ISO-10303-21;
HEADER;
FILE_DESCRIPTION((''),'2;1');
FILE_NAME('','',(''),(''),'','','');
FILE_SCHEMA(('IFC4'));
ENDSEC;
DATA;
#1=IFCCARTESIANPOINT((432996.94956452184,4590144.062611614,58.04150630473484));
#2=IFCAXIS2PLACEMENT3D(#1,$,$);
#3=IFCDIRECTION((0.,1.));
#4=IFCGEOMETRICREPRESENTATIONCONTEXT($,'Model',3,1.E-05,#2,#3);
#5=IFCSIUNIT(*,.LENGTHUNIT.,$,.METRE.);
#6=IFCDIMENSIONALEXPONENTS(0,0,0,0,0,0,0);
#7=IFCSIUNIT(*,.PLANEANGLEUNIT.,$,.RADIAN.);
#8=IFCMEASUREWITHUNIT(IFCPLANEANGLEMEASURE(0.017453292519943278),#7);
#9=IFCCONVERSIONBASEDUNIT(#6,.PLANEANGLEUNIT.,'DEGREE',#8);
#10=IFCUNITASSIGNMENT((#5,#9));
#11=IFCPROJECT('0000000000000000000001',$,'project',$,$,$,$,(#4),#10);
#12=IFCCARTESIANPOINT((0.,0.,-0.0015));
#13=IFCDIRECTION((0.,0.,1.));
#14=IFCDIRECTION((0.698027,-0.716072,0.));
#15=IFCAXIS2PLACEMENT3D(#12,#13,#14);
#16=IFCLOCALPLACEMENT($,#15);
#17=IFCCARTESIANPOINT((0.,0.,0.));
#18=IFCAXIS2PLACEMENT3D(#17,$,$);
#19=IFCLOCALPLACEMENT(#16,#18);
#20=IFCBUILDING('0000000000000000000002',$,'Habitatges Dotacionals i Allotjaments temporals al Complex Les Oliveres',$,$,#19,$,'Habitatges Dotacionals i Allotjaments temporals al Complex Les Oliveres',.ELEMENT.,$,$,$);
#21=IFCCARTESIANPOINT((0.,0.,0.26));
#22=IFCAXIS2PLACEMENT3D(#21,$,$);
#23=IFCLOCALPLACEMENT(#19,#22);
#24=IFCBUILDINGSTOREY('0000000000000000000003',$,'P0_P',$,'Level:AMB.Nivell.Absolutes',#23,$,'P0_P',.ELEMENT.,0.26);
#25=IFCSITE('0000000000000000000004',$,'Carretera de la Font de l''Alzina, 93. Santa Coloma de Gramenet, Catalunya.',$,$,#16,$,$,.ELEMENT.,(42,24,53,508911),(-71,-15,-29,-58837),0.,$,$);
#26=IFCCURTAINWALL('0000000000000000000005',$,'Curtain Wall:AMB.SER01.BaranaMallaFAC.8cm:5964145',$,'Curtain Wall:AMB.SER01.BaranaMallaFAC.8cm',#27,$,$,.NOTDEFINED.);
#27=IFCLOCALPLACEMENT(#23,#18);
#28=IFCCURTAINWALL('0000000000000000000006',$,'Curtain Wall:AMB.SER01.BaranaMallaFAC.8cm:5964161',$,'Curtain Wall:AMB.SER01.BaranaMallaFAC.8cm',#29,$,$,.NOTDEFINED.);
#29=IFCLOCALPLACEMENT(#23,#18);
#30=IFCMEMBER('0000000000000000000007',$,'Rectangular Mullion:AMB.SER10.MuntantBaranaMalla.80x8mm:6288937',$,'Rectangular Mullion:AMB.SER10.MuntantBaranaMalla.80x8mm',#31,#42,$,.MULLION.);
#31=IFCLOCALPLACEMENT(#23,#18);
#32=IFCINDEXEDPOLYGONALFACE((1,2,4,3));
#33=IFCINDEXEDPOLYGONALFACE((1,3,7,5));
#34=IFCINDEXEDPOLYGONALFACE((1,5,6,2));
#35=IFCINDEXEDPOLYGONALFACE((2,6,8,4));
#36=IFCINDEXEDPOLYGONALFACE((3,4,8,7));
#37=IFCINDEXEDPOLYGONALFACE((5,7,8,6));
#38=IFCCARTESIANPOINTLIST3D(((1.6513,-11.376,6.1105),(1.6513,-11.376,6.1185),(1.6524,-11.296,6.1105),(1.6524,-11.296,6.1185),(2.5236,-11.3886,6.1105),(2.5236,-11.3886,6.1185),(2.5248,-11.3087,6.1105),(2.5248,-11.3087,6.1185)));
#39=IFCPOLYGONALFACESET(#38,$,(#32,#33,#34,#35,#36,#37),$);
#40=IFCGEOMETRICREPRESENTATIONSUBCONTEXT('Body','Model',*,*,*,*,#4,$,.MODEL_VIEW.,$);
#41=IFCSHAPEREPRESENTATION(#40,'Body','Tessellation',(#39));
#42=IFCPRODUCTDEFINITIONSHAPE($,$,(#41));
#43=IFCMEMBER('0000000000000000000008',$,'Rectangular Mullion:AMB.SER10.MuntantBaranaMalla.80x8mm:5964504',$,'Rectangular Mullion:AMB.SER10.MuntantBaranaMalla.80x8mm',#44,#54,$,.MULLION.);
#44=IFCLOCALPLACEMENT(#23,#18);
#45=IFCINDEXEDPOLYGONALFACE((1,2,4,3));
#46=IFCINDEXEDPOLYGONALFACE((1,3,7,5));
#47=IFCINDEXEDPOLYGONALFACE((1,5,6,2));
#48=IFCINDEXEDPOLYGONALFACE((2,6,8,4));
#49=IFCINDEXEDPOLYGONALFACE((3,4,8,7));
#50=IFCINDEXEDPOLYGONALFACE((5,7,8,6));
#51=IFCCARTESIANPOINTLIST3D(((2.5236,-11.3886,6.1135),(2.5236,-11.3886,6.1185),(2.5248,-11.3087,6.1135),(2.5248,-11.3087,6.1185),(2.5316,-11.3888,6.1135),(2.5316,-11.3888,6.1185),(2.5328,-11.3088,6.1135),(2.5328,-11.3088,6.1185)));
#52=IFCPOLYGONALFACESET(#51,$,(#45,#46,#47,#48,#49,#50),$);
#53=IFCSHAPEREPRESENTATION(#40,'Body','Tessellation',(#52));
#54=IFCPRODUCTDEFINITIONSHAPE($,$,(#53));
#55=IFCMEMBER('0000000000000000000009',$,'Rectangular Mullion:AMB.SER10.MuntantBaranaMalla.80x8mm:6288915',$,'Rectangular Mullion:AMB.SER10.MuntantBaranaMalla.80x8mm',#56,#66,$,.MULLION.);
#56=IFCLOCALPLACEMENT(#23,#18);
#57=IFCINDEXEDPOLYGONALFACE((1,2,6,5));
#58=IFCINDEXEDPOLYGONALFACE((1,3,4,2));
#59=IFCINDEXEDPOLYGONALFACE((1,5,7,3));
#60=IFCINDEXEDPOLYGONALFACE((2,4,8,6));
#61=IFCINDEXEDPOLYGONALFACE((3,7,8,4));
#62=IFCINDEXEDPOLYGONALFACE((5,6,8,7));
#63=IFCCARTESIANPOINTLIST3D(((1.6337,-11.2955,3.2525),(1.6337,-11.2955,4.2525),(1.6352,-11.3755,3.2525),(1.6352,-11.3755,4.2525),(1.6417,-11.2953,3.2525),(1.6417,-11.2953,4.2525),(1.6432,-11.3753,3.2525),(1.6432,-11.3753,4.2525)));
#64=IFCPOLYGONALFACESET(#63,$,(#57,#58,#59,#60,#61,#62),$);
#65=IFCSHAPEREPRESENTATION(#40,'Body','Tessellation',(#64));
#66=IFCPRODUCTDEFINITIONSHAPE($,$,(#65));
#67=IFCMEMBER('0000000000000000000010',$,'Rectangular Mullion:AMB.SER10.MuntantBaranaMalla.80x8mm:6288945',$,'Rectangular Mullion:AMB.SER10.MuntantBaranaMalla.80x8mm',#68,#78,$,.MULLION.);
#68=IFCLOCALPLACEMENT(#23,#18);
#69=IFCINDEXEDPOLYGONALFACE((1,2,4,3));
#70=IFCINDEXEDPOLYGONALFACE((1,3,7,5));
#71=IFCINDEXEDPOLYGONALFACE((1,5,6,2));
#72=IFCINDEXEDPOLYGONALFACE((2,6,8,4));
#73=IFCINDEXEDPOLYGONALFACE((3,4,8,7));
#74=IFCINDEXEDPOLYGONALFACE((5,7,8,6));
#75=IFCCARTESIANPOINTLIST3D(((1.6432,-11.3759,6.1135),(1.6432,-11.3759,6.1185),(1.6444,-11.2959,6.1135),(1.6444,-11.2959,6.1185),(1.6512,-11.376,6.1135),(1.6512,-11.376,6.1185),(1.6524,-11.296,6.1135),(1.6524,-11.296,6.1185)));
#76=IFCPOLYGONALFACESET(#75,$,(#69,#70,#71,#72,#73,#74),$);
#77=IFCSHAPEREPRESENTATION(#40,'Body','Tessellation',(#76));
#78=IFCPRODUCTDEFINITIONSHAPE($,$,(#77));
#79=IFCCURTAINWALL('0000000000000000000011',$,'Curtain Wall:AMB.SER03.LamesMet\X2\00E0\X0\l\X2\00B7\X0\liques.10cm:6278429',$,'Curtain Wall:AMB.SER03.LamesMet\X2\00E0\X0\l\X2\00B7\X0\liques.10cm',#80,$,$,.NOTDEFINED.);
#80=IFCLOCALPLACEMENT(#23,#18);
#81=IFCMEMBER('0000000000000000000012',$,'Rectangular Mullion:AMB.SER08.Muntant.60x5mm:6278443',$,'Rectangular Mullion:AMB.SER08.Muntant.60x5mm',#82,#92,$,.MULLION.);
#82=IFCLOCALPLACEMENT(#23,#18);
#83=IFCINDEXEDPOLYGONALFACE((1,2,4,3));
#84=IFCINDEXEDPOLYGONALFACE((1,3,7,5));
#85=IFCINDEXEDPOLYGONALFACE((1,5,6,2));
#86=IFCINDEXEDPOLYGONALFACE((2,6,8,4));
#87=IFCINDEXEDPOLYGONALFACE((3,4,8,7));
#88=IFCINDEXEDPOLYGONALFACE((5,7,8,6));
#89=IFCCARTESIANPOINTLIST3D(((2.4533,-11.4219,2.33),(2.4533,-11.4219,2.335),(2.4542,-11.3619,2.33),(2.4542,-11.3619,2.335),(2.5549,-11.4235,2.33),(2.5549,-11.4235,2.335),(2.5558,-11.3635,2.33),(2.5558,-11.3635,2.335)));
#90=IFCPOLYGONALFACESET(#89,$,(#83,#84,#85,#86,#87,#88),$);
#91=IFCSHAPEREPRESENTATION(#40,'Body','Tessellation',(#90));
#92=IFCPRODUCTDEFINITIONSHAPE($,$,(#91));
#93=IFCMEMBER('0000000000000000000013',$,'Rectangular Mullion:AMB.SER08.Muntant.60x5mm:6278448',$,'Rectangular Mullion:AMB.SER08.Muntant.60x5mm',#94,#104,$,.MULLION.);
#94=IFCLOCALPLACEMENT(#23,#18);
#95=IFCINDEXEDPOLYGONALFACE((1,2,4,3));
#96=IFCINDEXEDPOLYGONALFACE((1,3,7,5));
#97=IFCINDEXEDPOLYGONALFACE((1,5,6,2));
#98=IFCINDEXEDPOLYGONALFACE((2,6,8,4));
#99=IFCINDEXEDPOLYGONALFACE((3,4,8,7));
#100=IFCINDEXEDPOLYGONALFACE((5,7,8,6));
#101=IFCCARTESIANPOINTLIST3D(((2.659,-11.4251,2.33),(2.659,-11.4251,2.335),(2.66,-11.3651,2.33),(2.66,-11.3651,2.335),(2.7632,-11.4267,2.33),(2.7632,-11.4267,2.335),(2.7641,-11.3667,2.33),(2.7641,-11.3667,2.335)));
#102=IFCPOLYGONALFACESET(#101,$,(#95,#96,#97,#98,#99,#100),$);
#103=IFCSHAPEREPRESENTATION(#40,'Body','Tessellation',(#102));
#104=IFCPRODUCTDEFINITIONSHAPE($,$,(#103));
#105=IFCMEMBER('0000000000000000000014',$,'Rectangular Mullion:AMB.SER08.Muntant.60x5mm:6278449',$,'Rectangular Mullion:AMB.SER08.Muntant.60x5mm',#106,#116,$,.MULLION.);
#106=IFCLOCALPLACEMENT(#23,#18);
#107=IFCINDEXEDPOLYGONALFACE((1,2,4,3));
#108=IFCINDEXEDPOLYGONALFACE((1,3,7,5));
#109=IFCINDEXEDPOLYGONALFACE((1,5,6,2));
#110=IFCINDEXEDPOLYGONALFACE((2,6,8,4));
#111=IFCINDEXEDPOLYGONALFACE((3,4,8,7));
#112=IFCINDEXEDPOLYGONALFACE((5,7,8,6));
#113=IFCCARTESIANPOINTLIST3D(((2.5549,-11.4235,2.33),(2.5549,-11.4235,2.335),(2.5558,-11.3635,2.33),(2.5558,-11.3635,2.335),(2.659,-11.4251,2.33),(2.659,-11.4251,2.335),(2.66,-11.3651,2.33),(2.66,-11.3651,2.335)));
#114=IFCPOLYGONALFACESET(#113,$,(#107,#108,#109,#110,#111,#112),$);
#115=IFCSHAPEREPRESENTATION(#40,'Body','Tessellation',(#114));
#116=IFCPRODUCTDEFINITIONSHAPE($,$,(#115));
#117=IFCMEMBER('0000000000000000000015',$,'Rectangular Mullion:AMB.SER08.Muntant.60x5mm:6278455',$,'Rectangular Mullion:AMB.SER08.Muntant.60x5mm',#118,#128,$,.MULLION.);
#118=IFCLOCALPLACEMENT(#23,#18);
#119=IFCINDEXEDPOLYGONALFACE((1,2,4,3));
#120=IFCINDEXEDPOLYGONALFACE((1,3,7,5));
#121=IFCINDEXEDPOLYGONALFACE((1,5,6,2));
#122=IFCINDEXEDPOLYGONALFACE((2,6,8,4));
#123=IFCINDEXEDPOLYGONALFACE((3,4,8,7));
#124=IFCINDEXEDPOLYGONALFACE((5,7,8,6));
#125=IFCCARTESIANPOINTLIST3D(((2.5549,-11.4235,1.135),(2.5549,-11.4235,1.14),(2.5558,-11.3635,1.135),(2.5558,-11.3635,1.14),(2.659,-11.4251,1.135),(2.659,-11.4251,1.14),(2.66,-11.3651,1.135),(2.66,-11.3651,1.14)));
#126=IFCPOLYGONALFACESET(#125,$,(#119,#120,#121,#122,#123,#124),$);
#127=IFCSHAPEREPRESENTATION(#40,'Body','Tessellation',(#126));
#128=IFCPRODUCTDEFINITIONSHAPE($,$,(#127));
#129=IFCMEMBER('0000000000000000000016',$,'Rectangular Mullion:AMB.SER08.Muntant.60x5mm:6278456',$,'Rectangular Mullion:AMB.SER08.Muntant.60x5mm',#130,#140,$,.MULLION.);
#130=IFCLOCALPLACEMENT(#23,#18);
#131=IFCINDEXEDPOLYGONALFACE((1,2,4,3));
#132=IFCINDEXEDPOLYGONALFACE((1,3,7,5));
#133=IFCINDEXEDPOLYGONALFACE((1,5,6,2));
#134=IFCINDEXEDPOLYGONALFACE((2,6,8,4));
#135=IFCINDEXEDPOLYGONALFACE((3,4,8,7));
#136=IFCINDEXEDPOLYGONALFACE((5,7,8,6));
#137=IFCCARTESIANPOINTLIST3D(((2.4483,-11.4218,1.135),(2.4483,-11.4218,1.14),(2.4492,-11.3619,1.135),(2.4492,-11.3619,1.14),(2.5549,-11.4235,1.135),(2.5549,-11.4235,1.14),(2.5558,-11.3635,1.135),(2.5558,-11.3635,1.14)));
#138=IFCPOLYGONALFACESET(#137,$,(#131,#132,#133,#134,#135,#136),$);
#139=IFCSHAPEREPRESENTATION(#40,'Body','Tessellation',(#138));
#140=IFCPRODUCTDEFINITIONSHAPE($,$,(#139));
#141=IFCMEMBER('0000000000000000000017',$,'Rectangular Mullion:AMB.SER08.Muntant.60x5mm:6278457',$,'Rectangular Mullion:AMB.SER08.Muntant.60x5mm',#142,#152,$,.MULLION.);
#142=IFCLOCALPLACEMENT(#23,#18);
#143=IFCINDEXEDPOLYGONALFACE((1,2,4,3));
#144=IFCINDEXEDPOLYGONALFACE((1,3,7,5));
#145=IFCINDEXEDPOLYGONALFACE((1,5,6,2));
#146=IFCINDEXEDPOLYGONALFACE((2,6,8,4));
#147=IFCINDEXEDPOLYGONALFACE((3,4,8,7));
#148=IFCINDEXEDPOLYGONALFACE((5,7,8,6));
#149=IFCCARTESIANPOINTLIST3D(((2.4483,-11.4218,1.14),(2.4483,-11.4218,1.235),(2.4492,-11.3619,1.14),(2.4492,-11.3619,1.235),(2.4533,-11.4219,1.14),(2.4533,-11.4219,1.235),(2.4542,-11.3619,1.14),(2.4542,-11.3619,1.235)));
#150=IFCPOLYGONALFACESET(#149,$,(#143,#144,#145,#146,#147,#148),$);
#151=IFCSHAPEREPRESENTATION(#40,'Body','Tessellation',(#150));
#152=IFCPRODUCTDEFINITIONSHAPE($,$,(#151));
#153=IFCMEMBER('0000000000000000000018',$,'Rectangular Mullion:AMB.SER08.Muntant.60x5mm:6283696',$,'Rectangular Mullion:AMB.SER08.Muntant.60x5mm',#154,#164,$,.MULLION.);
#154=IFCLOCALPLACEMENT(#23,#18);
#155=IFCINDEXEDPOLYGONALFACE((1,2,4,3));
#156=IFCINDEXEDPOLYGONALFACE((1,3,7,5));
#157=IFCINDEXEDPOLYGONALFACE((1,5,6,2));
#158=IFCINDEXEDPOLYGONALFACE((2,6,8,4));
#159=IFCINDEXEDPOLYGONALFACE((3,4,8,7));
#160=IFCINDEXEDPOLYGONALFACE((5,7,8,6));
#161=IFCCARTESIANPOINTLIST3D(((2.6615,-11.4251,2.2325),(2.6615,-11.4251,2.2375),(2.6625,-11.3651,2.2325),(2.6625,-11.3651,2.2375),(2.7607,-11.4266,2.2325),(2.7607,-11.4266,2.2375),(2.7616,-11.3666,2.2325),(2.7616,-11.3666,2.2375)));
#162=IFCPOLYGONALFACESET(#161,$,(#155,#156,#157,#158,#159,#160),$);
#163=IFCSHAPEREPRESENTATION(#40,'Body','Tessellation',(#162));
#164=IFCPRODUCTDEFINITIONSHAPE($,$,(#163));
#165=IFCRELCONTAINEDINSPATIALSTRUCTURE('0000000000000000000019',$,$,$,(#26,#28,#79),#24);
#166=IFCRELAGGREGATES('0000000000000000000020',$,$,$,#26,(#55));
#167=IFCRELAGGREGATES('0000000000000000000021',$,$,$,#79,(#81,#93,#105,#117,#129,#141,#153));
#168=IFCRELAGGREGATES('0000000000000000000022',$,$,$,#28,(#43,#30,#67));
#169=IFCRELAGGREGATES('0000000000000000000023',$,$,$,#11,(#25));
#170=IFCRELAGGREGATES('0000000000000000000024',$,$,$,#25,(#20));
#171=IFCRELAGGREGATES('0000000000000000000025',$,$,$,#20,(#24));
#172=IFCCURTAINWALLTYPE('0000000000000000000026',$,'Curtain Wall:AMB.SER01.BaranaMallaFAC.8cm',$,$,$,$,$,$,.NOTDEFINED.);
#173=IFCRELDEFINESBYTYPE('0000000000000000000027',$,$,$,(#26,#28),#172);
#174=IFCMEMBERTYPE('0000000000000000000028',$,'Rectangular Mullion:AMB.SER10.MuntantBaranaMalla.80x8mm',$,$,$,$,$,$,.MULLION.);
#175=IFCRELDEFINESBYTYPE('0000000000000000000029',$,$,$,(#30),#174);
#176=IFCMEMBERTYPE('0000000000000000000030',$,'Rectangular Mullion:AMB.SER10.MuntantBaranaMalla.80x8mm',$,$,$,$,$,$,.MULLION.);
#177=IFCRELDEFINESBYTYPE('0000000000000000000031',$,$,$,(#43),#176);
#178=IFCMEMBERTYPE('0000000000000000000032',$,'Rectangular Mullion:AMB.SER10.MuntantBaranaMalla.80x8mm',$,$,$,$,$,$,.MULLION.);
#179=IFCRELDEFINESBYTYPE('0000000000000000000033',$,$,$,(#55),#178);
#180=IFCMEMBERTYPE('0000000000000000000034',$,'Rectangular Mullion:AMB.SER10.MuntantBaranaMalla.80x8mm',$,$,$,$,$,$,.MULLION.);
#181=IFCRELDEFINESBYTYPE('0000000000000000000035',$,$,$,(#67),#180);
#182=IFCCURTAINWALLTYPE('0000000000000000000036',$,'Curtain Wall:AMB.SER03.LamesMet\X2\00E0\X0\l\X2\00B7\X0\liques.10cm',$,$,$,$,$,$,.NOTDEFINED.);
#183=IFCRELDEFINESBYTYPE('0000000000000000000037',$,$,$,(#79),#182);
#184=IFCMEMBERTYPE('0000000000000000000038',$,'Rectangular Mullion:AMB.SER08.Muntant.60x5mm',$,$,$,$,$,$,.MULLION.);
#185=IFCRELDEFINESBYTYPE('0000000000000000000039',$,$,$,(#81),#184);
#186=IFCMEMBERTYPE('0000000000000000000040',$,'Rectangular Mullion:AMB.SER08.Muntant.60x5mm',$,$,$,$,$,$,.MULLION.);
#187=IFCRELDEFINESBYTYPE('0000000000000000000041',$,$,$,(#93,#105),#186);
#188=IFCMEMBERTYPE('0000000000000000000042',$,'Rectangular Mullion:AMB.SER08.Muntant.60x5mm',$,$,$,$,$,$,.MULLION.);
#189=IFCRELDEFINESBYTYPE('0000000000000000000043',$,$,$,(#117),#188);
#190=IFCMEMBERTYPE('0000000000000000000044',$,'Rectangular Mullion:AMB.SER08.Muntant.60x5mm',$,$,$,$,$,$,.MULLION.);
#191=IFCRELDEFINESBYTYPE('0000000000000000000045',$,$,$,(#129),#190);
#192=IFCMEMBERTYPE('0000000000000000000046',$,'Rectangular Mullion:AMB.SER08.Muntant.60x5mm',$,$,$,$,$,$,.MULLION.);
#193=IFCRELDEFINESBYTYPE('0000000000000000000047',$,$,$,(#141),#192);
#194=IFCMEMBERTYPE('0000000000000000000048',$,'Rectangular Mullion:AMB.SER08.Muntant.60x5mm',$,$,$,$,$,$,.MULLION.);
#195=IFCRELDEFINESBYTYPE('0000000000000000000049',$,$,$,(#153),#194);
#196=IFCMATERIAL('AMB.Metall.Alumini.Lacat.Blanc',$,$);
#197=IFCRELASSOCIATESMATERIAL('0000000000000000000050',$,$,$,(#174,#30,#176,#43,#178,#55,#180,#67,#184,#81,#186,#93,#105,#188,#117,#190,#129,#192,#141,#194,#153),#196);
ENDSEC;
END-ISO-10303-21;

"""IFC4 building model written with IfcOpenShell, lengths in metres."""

from ifc_helpers import new_model, entity, si_unit, converted_unit, direction, frame, origin, place, context, subcontext, project, spatial, indexed_curve, outline, extrude, source, transform, mapped, material, type_object, type_shapes, element, aggregate, save


model = new_model("IFC4")

# Units and contexts
model_context = context("Model", 3, precision=1e-05, world=frame((432996.94956452184, 4590144.062611614, 58.04150630473484)), true_north=direction((0.0, 1.0)))
body_context = subcontext(model_context, "Body", "Model", "MODEL_VIEW")
ifc_project = project(units=[si_unit("LENGTHUNIT", "METRE"), converted_unit("PLANEANGLEUNIT", "DEGREE", entity("IfcPlaneAngleMeasure", 0.017453292519943278), si_unit("PLANEANGLEUNIT", "RADIAN"), dimensions=[0, 0, 0, 0, 0, 0, 0])], contexts=[model_context])

# Site, building, storey
site_placement = place(None, frame((0.0, 0.0, -0.0015), z_axis=(0.0, 0.0, 1.0), x_axis=(0.698027, -0.716072, 0.0)))
site = spatial("IfcSite", under=ifc_project, at=site_placement, Name="Carretera de la Font de l'Alzina, 93. Santa Coloma de Gramenet, Catalunya.", CompositionType="ELEMENT", RefLatitude=(42, 24, 53, 508911), RefLongitude=(-71, -15, -29, -58837), RefElevation=0.0)
building_placement = place(site_placement, origin())
building = spatial("IfcBuilding", under=site, at=building_placement, Name="Habitatges Dotacionals i Allotjaments temporals al Complex Les Oliveres", LongName="Habitatges Dotacionals i Allotjaments temporals al Complex Les Oliveres", CompositionType="ELEMENT")
storey_placement = place(building_placement, frame((0.0, 0.0, 0.26)))
storey = spatial("IfcBuildingStorey", under=building, at=storey_placement, Name="P0_P", ObjectType="Level:AMB.Nivell.Absolutes", LongName="P0_P", CompositionType="ELEMENT", Elevation=0.26)

# Curtain wall
curtain_wall_type_1 = type_object("IfcCurtainWallType", Name="Curtain Wall:AMB.SER01.BaranaMallaFAC.8cm", PredefinedType="NOTDEFINED")
curtain_wall_1_placement = place(storey_placement, frame((0.0, 0.0, -0.26)))
curtain_wall_1 = element("IfcCurtainWall", 1, at=curtain_wall_1_placement, inside=storey, type_object=curtain_wall_type_1, Name="Curtain Wall:AMB.SER01.BaranaMallaFAC.8cm:5964145", ObjectType="Curtain Wall:AMB.SER01.BaranaMallaFAC.8cm", PredefinedType="NOTDEFINED")
ifc_material_1 = material(Name="AMB.Metall.Alumini.Lacat.Blanc")

# Curtain wall, members
curtain_wall_2_placement = place(storey_placement, frame((0.0, 0.0, -0.26)))
curtain_wall_2 = element("IfcCurtainWall", 2, at=curtain_wall_2_placement, inside=storey, type_object=curtain_wall_type_1, Name="Curtain Wall:AMB.SER01.BaranaMallaFAC.8cm:5964161", ObjectType="Curtain Wall:AMB.SER01.BaranaMallaFAC.8cm", PredefinedType="NOTDEFINED")
member_type_1 = type_object("IfcMemberType", Name="Rectangular Mullion:AMB.SER10.MuntantBaranaMalla.80x8mm", PredefinedType="MULLION", material=ifc_material_1)
shared_shape_1 = source(origin(), body_context, "Body", "SweptSolid", [
    extrude(outline(indexed_curve([(-0.004, -0.04), (0.004, -0.04), (0.004, 0.04), (-0.004, 0.04), (-0.004, -0.04)], self_intersect=False)), frame((-0.004, -0.04, -0.8724), z_axis=(0.0, 0.0, 1.0), x_axis=(-1.0, 0.0, 0.0)), (0.0, 0.0, 1.0), 0.8724),
])
type_shapes(member_type_1, [shared_shape_1])
member_1_placement = place(curtain_wall_2_placement, frame((2.5236, -11.3886, 6.3785), z_axis=(0.999895, -0.014473, 0.0), x_axis=(0.0, 0.0, 1.0)))
member_1 = element("IfcMember", 3, at=member_1_placement, type_object=member_type_1, material=ifc_material_1, Name="Rectangular Mullion:AMB.SER10.MuntantBaranaMalla.80x8mm:6288937", ObjectType="Rectangular Mullion:AMB.SER10.MuntantBaranaMalla.80x8mm", PredefinedType="MULLION", context=body_context, shape_type="MappedRepresentation", body=[
    mapped(shared_shape_1, transform((0.0, 0.0, 0.0), scale=1.0)),
])
member_type_2 = type_object("IfcMemberType", Name="Rectangular Mullion:AMB.SER10.MuntantBaranaMalla.80x8mm", PredefinedType="MULLION", material=ifc_material_1)
shared_shape_2 = source(origin(), body_context, "Body", "SweptSolid", [
    extrude(outline(indexed_curve([(-0.004, -0.04), (0.004, -0.04), (0.004, 0.04), (-0.004, 0.04), (-0.004, -0.04)], self_intersect=False)), frame((0.0, -0.04, -0.005), z_axis=(0.0, 0.0, 1.0), x_axis=(-1.0, 0.0, 0.0)), (0.0, 0.0, 1.0), 0.005),
])
type_shapes(member_type_2, [shared_shape_2])
member_2_placement = place(curtain_wall_2_placement, frame((2.5276, -11.3887, 6.3735), z_axis=(0.0, 0.0, -1.0), x_axis=(0.999895, -0.014473, 0.0)))
member_2 = element("IfcMember", 4, at=member_2_placement, type_object=member_type_2, material=ifc_material_1, Name="Rectangular Mullion:AMB.SER10.MuntantBaranaMalla.80x8mm:5964504", ObjectType="Rectangular Mullion:AMB.SER10.MuntantBaranaMalla.80x8mm", PredefinedType="MULLION", context=body_context, shape_type="MappedRepresentation", body=[
    mapped(shared_shape_2, transform((0.0, 0.0, 0.0), scale=1.0)),
])

# Members
member_type_3 = type_object("IfcMemberType", Name="Rectangular Mullion:AMB.SER10.MuntantBaranaMalla.80x8mm", PredefinedType="MULLION", material=ifc_material_1)
shared_shape_3 = source(origin(), body_context, "Body", "SweptSolid", [
    extrude(outline(indexed_curve([(-0.004, -0.04), (0.004, -0.04), (0.004, 0.04), (-0.004, 0.04), (-0.004, -0.04)], self_intersect=False)), frame((-0.004, -0.04, -1.0), z_axis=(0.0, 0.0, 1.0), x_axis=(-1.0, 0.0, 0.0)), (0.0, 0.0, 1.0), 1.0),
])
type_shapes(member_type_3, [shared_shape_3])
member_3_placement = place(curtain_wall_1_placement, frame((1.6432, -11.3753, 3.5125), z_axis=(0.0, 0.0, -1.0), x_axis=(0.999822, 0.018842, 0.0)))
member_3 = element("IfcMember", 5, at=member_3_placement, type_object=member_type_3, material=ifc_material_1, Name="Rectangular Mullion:AMB.SER10.MuntantBaranaMalla.80x8mm:6288915", ObjectType="Rectangular Mullion:AMB.SER10.MuntantBaranaMalla.80x8mm", PredefinedType="MULLION", context=body_context, shape_type="MappedRepresentation", body=[
    mapped(shared_shape_3, transform((0.0, 0.0, 0.0), scale=1.0)),
])
aggregate(curtain_wall_1, [member_3])
member_type_4 = type_object("IfcMemberType", Name="Rectangular Mullion:AMB.SER10.MuntantBaranaMalla.80x8mm", PredefinedType="MULLION", material=ifc_material_1)
shared_shape_4 = source(origin(), body_context, "Body", "SweptSolid", [
    extrude(outline(indexed_curve([(-0.004, -0.04), (0.004, -0.04), (0.004, 0.04), (-0.004, 0.04), (-0.004, -0.04)], self_intersect=False)), frame((-0.004, -0.04, -0.005), z_axis=(0.0, 0.0, 1.0), x_axis=(-1.0, 0.0, 0.0)), (0.0, 0.0, 1.0), 0.005),
])
type_shapes(member_type_4, [shared_shape_4])
member_4_placement = place(curtain_wall_2_placement, frame((1.6432, -11.3759, 6.3785), z_axis=(0.0, 0.0, 1.0), x_axis=(-0.999895, 0.014473, 0.0)))
member_4 = element("IfcMember", 6, at=member_4_placement, type_object=member_type_4, material=ifc_material_1, Name="Rectangular Mullion:AMB.SER10.MuntantBaranaMalla.80x8mm:6288945", ObjectType="Rectangular Mullion:AMB.SER10.MuntantBaranaMalla.80x8mm", PredefinedType="MULLION", context=body_context, shape_type="MappedRepresentation", body=[
    mapped(shared_shape_4, transform((0.0, 0.0, 0.0), scale=1.0)),
])

# Curtain wall, members
curtain_wall_type_2 = type_object("IfcCurtainWallType", Name="Curtain Wall:AMB.SER03.LamesMetàl·liques.10cm", PredefinedType="NOTDEFINED")
curtain_wall_3_placement = place(storey_placement, frame((0.0, 0.0, -0.26)))
curtain_wall_3 = element("IfcCurtainWall", 7, at=curtain_wall_3_placement, inside=storey, type_object=curtain_wall_type_2, Name="Curtain Wall:AMB.SER03.LamesMetàl·liques.10cm:6278429", ObjectType="Curtain Wall:AMB.SER03.LamesMetàl·liques.10cm", PredefinedType="NOTDEFINED")
member_type_5 = type_object("IfcMemberType", Name="Rectangular Mullion:AMB.SER08.Muntant.60x5mm", PredefinedType="MULLION", material=ifc_material_1)
shared_shape_5 = source(origin(), body_context, "Body", "SweptSolid", [
    extrude(outline(indexed_curve([(-0.0025, -0.03), (0.0025, -0.03), (0.0025, 0.03), (-0.0025, 0.03), (-0.0025, -0.03)], self_intersect=False)), frame((-0.0025, 0.03, -0.1016), z_axis=(0.0, 0.0, 1.0), x_axis=(-1.0, 0.0, 0.0)), (0.0, 0.0, 1.0), 0.1016),
])
type_shapes(member_type_5, [shared_shape_5])
member_5_placement = place(curtain_wall_3_placement, frame((2.4533, -11.4219, 2.595), z_axis=(-0.999883, 0.015319, 0.0), x_axis=(0.0, 0.0, 1.0)))
member_5 = element("IfcMember", 8, at=member_5_placement, type_object=member_type_5, material=ifc_material_1, Name="Rectangular Mullion:AMB.SER08.Muntant.60x5mm:6278443", ObjectType="Rectangular Mullion:AMB.SER08.Muntant.60x5mm", PredefinedType="MULLION", context=body_context, shape_type="MappedRepresentation", body=[
    mapped(shared_shape_5, transform((0.0, 0.0, 0.0), scale=1.0)),
])
member_type_6 = type_object("IfcMemberType", Name="Rectangular Mullion:AMB.SER08.Muntant.60x5mm", PredefinedType="MULLION", material=ifc_material_1)
shared_shape_6 = source(origin(), body_context, "Body", "SweptSolid", [
    extrude(outline(indexed_curve([(-0.0025, -0.03), (0.0025, -0.03), (0.0025, 0.03), (-0.0025, 0.03), (-0.0025, -0.03)], self_intersect=False)), frame((-0.0025, 0.03, -0.1041), z_axis=(0.0, 0.0, 1.0), x_axis=(-1.0, 0.0, 0.0)), (0.0, 0.0, 1.0), 0.1041),
])
type_shapes(member_type_6, [shared_shape_6])
member_6_placement = place(curtain_wall_3_placement, frame((2.659, -11.4251, 2.595), z_axis=(-0.999883, 0.015319, 0.0), x_axis=(0.0, 0.0, 1.0)))
member_6 = element("IfcMember", 9, at=member_6_placement, type_object=member_type_6, material=ifc_material_1, Name="Rectangular Mullion:AMB.SER08.Muntant.60x5mm:6278448", ObjectType="Rectangular Mullion:AMB.SER08.Muntant.60x5mm", PredefinedType="MULLION", context=body_context, shape_type="MappedRepresentation", body=[
    mapped(shared_shape_6, transform((0.0, 0.0, 0.0), scale=1.0)),
])
member_7_placement = place(curtain_wall_3_placement, frame((2.5549, -11.4235, 2.595), z_axis=(-0.999883, 0.015319, 0.0), x_axis=(0.0, 0.0, 1.0)))
member_7 = element("IfcMember", 10, at=member_7_placement, type_object=member_type_6, material=ifc_material_1, Name="Rectangular Mullion:AMB.SER08.Muntant.60x5mm:6278449", ObjectType="Rectangular Mullion:AMB.SER08.Muntant.60x5mm", PredefinedType="MULLION", context=body_context, shape_type="MappedRepresentation", body=[
    mapped(shared_shape_6, transform((0.0, 0.0, 0.0), scale=1.0)),
])
member_type_7 = type_object("IfcMemberType", Name="Rectangular Mullion:AMB.SER08.Muntant.60x5mm", PredefinedType="MULLION", material=ifc_material_1)
shared_shape_7 = source(origin(), body_context, "Body", "SweptSolid", [
    extrude(outline(indexed_curve([(-0.0025, -0.03), (0.0025, -0.03), (0.0025, 0.03), (-0.0025, 0.03), (-0.0025, -0.03)], self_intersect=False)), frame((-0.0025, 0.03, -0.1041), z_axis=(0.0, 0.0, 1.0), x_axis=(-1.0, 0.0, 0.0)), (0.0, 0.0, 1.0), 0.1041),
])
type_shapes(member_type_7, [shared_shape_7])
member_8_placement = place(curtain_wall_3_placement, frame((2.659, -11.4251, 1.395), z_axis=(0.999883, -0.015319, 0.0), x_axis=(0.0, 0.0, -1.0)))
member_8 = element("IfcMember", 11, at=member_8_placement, type_object=member_type_7, material=ifc_material_1, Name="Rectangular Mullion:AMB.SER08.Muntant.60x5mm:6278455", ObjectType="Rectangular Mullion:AMB.SER08.Muntant.60x5mm", PredefinedType="MULLION", context=body_context, shape_type="MappedRepresentation", body=[
    mapped(shared_shape_7, transform((0.0, 0.0, 0.0), scale=1.0)),
])
member_type_8 = type_object("IfcMemberType", Name="Rectangular Mullion:AMB.SER08.Muntant.60x5mm", PredefinedType="MULLION", material=ifc_material_1)
shared_shape_8 = source(origin(), body_context, "Body", "SweptSolid", [
    extrude(outline(indexed_curve([(-0.0025, -0.03), (0.0025, -0.03), (0.0025, 0.03), (-0.0025, 0.03), (-0.0025, -0.03)], self_intersect=False)), frame((-0.0025, 0.03, -0.1066), z_axis=(0.0, 0.0, 1.0), x_axis=(-1.0, 0.0, 0.0)), (0.0, 0.0, 1.0), 0.1066),
])
type_shapes(member_type_8, [shared_shape_8])
member_9_placement = place(curtain_wall_3_placement, frame((2.5549, -11.4235, 1.395), z_axis=(0.999883, -0.015319, 0.0), x_axis=(0.0, 0.0, -1.0)))
member_9 = element("IfcMember", 12, at=member_9_placement, type_object=member_type_8, material=ifc_material_1, Name="Rectangular Mullion:AMB.SER08.Muntant.60x5mm:6278456", ObjectType="Rectangular Mullion:AMB.SER08.Muntant.60x5mm", PredefinedType="MULLION", context=body_context, shape_type="MappedRepresentation", body=[
    mapped(shared_shape_8, transform((0.0, 0.0, 0.0), scale=1.0)),
])
member_type_9 = type_object("IfcMemberType", Name="Rectangular Mullion:AMB.SER08.Muntant.60x5mm", PredefinedType="MULLION", material=ifc_material_1)
shared_shape_9 = source(origin(), body_context, "Body", "SweptSolid", [
    extrude(outline(indexed_curve([(-0.0025, -0.03), (0.0025, -0.03), (0.0025, 0.03), (-0.0025, 0.03), (-0.0025, -0.03)], self_intersect=False)), frame((-0.0025, 0.03, -0.095), z_axis=(0.0, 0.0, 1.0), x_axis=(-1.0, 0.0, 0.0)), (0.0, 0.0, 1.0), 0.095),
])
type_shapes(member_type_9, [shared_shape_9])
member_10_placement = place(curtain_wall_3_placement, frame((2.4483, -11.4218, 1.4), z_axis=(0.0, 0.0, -1.0), x_axis=(-0.999883, 0.015319, 0.0)))
member_10 = element("IfcMember", 13, at=member_10_placement, type_object=member_type_9, material=ifc_material_1, Name="Rectangular Mullion:AMB.SER08.Muntant.60x5mm:6278457", ObjectType="Rectangular Mullion:AMB.SER08.Muntant.60x5mm", PredefinedType="MULLION", context=body_context, shape_type="MappedRepresentation", body=[
    mapped(shared_shape_9, transform((0.0, 0.0, 0.0), scale=1.0)),
])
member_type_10 = type_object("IfcMemberType", Name="Rectangular Mullion:AMB.SER08.Muntant.60x5mm", PredefinedType="MULLION", material=ifc_material_1)
shared_shape_10 = source(origin(), body_context, "Body", "SweptSolid", [
    extrude(outline(indexed_curve([(-0.0025, -0.03), (0.0025, -0.03), (0.0025, 0.03), (-0.0025, 0.03), (-0.0025, -0.03)], self_intersect=False)), frame((0.0, 0.03, -0.0991), z_axis=(0.0, 0.0, 1.0), x_axis=(-1.0, 0.0, 0.0)), (0.0, 0.0, 1.0), 0.0991),
])
type_shapes(member_type_10, [shared_shape_10])
member_11_placement = place(curtain_wall_3_placement, frame((2.6615, -11.4251, 2.495), z_axis=(-0.999883, 0.015319, 0.0), x_axis=(0.0, 0.0, 1.0)))
member_11 = element("IfcMember", 14, at=member_11_placement, type_object=member_type_10, material=ifc_material_1, Name="Rectangular Mullion:AMB.SER08.Muntant.60x5mm:6283696", ObjectType="Rectangular Mullion:AMB.SER08.Muntant.60x5mm", PredefinedType="MULLION", context=body_context, shape_type="MappedRepresentation", body=[
    mapped(shared_shape_10, transform((0.0, 0.0, 0.0), scale=1.0)),
])
aggregate(curtain_wall_3, [member_5, member_6, member_7, member_8, member_9, member_10, member_11])

aggregate(curtain_wall_2, [member_2, member_1, member_4])

save(model, "model.ifc")
